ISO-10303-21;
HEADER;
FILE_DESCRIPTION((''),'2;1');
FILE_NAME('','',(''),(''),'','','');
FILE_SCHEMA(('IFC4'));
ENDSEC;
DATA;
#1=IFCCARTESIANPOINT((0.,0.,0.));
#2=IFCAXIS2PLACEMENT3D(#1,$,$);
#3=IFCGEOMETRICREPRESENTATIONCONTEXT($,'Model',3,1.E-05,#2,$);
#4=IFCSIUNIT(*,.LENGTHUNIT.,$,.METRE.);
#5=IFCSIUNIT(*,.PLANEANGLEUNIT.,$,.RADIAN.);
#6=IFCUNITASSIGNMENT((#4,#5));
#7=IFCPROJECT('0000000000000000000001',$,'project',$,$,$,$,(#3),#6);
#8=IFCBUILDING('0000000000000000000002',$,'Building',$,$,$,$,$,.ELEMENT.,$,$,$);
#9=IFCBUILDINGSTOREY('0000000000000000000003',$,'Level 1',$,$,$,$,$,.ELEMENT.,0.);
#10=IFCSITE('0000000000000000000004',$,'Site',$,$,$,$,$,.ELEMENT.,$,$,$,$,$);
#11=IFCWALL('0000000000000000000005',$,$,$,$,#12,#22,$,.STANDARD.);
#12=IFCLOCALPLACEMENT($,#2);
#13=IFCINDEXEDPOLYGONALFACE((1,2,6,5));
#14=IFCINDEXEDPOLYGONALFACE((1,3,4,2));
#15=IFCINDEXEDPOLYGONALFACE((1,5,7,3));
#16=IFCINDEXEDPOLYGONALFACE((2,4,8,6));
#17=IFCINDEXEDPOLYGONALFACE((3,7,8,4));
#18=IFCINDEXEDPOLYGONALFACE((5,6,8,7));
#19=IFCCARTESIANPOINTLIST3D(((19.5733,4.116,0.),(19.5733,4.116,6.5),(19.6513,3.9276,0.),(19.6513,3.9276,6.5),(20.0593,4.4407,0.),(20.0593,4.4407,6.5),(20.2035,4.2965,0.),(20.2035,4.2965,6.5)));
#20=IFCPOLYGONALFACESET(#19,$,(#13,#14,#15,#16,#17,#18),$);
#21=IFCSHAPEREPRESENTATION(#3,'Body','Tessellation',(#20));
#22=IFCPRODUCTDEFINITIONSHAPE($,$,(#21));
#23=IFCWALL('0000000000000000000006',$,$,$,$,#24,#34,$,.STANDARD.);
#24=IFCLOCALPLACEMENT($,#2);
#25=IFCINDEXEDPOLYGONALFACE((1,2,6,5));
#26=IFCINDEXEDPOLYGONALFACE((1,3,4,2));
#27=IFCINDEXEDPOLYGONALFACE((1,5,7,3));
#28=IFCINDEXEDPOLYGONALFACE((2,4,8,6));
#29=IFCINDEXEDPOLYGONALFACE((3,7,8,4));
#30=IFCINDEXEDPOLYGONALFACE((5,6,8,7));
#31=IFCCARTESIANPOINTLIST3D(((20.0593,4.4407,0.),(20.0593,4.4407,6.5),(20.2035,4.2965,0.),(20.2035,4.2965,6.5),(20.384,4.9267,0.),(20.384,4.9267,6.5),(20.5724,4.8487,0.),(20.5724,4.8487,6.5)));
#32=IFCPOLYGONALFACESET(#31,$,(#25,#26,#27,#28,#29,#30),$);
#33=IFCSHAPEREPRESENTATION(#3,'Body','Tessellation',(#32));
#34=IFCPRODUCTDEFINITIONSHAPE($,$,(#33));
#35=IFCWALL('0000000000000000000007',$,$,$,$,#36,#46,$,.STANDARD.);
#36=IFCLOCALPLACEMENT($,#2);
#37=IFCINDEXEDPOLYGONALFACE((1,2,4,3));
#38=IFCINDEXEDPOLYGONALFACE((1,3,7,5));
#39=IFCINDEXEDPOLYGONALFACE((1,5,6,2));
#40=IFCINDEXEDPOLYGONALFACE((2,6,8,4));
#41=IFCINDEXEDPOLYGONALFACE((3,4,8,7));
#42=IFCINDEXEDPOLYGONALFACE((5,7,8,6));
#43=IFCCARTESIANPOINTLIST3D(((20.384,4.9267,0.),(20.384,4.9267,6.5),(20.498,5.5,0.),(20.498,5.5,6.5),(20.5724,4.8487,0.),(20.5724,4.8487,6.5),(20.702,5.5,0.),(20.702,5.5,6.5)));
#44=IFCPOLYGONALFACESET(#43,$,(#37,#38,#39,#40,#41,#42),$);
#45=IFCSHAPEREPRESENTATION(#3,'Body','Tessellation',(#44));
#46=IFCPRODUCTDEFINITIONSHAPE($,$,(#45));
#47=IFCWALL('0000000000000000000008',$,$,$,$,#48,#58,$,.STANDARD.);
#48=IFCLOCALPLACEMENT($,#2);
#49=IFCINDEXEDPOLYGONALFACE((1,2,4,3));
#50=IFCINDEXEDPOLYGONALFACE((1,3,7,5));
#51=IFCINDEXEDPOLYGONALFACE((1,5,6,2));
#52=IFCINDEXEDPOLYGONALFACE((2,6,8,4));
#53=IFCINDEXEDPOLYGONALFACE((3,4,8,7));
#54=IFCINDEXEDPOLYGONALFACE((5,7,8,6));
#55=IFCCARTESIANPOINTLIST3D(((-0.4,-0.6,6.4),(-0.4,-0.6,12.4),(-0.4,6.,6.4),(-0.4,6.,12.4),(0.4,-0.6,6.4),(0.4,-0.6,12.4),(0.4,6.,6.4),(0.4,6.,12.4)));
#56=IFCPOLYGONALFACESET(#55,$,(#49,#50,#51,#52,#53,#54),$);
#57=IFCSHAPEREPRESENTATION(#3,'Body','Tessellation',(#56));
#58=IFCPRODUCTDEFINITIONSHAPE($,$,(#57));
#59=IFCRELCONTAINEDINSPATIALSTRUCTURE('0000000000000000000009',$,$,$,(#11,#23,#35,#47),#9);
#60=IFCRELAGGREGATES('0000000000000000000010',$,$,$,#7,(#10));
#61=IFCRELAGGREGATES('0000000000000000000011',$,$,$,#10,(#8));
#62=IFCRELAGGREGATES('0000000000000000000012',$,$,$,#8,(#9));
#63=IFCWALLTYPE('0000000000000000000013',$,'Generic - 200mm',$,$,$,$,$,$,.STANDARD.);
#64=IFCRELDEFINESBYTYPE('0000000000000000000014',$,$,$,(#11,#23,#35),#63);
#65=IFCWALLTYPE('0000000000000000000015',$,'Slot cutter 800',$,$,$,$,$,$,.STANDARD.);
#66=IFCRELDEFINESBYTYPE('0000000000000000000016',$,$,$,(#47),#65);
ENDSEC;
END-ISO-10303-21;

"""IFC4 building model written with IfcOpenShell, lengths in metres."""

from ifc_helpers import new_model, si_unit, frame, frame_2d, origin, place, context, project, spatial, polyline, rectangle, outline, extrude, type_object, element, save


model = new_model("IFC4")

# Units and contexts
model_context = context("Model", 3, precision=1e-05, world=origin())
ifc_project = project(units=[si_unit("LENGTHUNIT", "METRE"), si_unit("PLANEANGLEUNIT", "RADIAN")], contexts=[model_context])

# Site, building, storey
site = spatial("IfcSite", under=ifc_project, Name="Site", CompositionType="ELEMENT")
building = spatial("IfcBuilding", under=site, Name="Building", CompositionType="ELEMENT")
storey = spatial("IfcBuildingStorey", under=building, Name="Level 1", CompositionType="ELEMENT", Elevation=0.0)

# Shared definitions
wall_type_1 = type_object("IfcWallType", Name="Generic - 200mm", PredefinedType="STANDARD")

# Walls
wall_1_placement = place(None, frame((20.1314, 4.3686, 0.0), z_axis=(0.0, 0.0, 1.0), x_axis=(-0.83147, -0.55557, 0.0)))
element("IfcWall", 1, at=wall_1_placement, inside=storey, type_object=wall_type_1, PredefinedType="STANDARD", context=model_context, shape_type="SweptSolid", body=[
    extrude(outline(polyline([(0.0199, -0.1), (0.6044, -0.1), (0.6442, 0.1), (-0.0199, 0.1), (0.0199, -0.1)])), origin(), (0.0, 0.0, 1.0), 6.5),
])
wall_2_placement = place(None, frame((20.4782, 4.8877, 0.0), z_axis=(0.0, 0.0, 1.0), x_axis=(-0.55557, -0.83147, 0.0)))
element("IfcWall", 2, at=wall_2_placement, inside=storey, type_object=wall_type_1, PredefinedType="STANDARD", context=model_context, shape_type="SweptSolid", body=[
    extrude(outline(polyline([(0.0199, -0.1), (0.6044, -0.1), (0.6442, 0.1), (-0.0199, 0.1), (0.0199, -0.1)])), origin(), (0.0, 0.0, 1.0), 6.5),
])
wall_3_placement = place(None, frame((20.6, 5.5, 0.0), z_axis=(0.0, 0.0, 1.0), x_axis=(-0.19509, -0.980785, 0.0)))
element("IfcWall", 3, at=wall_3_placement, inside=storey, type_object=wall_type_1, PredefinedType="STANDARD", context=model_context, shape_type="SweptSolid", body=[
    extrude(outline(polyline([(0.0199, -0.1), (0.6044, -0.1), (0.6442, 0.1), (-0.0199, 0.1), (0.0199, -0.1)])), origin(), (0.0, 0.0, 1.0), 6.5),
])
wall_type_2 = type_object("IfcWallType", Name="Slot cutter 800", PredefinedType="STANDARD")
wall_4_placement = place(None, frame((0.0, -0.6, 6.4), z_axis=(0.0, 0.0, 1.0), x_axis=(0.0, 1.0, 0.0)))
element("IfcWall", 4, at=wall_4_placement, inside=storey, type_object=wall_type_2, PredefinedType="STANDARD", context=model_context, shape_type="SweptSolid", body=[
    extrude(rectangle(XDim=6.6, YDim=0.8, at=frame_2d((3.3, 0.0))), origin(), (0.0, 0.0, 1.0), 6.0),
])

save(model, "model.ifc")
